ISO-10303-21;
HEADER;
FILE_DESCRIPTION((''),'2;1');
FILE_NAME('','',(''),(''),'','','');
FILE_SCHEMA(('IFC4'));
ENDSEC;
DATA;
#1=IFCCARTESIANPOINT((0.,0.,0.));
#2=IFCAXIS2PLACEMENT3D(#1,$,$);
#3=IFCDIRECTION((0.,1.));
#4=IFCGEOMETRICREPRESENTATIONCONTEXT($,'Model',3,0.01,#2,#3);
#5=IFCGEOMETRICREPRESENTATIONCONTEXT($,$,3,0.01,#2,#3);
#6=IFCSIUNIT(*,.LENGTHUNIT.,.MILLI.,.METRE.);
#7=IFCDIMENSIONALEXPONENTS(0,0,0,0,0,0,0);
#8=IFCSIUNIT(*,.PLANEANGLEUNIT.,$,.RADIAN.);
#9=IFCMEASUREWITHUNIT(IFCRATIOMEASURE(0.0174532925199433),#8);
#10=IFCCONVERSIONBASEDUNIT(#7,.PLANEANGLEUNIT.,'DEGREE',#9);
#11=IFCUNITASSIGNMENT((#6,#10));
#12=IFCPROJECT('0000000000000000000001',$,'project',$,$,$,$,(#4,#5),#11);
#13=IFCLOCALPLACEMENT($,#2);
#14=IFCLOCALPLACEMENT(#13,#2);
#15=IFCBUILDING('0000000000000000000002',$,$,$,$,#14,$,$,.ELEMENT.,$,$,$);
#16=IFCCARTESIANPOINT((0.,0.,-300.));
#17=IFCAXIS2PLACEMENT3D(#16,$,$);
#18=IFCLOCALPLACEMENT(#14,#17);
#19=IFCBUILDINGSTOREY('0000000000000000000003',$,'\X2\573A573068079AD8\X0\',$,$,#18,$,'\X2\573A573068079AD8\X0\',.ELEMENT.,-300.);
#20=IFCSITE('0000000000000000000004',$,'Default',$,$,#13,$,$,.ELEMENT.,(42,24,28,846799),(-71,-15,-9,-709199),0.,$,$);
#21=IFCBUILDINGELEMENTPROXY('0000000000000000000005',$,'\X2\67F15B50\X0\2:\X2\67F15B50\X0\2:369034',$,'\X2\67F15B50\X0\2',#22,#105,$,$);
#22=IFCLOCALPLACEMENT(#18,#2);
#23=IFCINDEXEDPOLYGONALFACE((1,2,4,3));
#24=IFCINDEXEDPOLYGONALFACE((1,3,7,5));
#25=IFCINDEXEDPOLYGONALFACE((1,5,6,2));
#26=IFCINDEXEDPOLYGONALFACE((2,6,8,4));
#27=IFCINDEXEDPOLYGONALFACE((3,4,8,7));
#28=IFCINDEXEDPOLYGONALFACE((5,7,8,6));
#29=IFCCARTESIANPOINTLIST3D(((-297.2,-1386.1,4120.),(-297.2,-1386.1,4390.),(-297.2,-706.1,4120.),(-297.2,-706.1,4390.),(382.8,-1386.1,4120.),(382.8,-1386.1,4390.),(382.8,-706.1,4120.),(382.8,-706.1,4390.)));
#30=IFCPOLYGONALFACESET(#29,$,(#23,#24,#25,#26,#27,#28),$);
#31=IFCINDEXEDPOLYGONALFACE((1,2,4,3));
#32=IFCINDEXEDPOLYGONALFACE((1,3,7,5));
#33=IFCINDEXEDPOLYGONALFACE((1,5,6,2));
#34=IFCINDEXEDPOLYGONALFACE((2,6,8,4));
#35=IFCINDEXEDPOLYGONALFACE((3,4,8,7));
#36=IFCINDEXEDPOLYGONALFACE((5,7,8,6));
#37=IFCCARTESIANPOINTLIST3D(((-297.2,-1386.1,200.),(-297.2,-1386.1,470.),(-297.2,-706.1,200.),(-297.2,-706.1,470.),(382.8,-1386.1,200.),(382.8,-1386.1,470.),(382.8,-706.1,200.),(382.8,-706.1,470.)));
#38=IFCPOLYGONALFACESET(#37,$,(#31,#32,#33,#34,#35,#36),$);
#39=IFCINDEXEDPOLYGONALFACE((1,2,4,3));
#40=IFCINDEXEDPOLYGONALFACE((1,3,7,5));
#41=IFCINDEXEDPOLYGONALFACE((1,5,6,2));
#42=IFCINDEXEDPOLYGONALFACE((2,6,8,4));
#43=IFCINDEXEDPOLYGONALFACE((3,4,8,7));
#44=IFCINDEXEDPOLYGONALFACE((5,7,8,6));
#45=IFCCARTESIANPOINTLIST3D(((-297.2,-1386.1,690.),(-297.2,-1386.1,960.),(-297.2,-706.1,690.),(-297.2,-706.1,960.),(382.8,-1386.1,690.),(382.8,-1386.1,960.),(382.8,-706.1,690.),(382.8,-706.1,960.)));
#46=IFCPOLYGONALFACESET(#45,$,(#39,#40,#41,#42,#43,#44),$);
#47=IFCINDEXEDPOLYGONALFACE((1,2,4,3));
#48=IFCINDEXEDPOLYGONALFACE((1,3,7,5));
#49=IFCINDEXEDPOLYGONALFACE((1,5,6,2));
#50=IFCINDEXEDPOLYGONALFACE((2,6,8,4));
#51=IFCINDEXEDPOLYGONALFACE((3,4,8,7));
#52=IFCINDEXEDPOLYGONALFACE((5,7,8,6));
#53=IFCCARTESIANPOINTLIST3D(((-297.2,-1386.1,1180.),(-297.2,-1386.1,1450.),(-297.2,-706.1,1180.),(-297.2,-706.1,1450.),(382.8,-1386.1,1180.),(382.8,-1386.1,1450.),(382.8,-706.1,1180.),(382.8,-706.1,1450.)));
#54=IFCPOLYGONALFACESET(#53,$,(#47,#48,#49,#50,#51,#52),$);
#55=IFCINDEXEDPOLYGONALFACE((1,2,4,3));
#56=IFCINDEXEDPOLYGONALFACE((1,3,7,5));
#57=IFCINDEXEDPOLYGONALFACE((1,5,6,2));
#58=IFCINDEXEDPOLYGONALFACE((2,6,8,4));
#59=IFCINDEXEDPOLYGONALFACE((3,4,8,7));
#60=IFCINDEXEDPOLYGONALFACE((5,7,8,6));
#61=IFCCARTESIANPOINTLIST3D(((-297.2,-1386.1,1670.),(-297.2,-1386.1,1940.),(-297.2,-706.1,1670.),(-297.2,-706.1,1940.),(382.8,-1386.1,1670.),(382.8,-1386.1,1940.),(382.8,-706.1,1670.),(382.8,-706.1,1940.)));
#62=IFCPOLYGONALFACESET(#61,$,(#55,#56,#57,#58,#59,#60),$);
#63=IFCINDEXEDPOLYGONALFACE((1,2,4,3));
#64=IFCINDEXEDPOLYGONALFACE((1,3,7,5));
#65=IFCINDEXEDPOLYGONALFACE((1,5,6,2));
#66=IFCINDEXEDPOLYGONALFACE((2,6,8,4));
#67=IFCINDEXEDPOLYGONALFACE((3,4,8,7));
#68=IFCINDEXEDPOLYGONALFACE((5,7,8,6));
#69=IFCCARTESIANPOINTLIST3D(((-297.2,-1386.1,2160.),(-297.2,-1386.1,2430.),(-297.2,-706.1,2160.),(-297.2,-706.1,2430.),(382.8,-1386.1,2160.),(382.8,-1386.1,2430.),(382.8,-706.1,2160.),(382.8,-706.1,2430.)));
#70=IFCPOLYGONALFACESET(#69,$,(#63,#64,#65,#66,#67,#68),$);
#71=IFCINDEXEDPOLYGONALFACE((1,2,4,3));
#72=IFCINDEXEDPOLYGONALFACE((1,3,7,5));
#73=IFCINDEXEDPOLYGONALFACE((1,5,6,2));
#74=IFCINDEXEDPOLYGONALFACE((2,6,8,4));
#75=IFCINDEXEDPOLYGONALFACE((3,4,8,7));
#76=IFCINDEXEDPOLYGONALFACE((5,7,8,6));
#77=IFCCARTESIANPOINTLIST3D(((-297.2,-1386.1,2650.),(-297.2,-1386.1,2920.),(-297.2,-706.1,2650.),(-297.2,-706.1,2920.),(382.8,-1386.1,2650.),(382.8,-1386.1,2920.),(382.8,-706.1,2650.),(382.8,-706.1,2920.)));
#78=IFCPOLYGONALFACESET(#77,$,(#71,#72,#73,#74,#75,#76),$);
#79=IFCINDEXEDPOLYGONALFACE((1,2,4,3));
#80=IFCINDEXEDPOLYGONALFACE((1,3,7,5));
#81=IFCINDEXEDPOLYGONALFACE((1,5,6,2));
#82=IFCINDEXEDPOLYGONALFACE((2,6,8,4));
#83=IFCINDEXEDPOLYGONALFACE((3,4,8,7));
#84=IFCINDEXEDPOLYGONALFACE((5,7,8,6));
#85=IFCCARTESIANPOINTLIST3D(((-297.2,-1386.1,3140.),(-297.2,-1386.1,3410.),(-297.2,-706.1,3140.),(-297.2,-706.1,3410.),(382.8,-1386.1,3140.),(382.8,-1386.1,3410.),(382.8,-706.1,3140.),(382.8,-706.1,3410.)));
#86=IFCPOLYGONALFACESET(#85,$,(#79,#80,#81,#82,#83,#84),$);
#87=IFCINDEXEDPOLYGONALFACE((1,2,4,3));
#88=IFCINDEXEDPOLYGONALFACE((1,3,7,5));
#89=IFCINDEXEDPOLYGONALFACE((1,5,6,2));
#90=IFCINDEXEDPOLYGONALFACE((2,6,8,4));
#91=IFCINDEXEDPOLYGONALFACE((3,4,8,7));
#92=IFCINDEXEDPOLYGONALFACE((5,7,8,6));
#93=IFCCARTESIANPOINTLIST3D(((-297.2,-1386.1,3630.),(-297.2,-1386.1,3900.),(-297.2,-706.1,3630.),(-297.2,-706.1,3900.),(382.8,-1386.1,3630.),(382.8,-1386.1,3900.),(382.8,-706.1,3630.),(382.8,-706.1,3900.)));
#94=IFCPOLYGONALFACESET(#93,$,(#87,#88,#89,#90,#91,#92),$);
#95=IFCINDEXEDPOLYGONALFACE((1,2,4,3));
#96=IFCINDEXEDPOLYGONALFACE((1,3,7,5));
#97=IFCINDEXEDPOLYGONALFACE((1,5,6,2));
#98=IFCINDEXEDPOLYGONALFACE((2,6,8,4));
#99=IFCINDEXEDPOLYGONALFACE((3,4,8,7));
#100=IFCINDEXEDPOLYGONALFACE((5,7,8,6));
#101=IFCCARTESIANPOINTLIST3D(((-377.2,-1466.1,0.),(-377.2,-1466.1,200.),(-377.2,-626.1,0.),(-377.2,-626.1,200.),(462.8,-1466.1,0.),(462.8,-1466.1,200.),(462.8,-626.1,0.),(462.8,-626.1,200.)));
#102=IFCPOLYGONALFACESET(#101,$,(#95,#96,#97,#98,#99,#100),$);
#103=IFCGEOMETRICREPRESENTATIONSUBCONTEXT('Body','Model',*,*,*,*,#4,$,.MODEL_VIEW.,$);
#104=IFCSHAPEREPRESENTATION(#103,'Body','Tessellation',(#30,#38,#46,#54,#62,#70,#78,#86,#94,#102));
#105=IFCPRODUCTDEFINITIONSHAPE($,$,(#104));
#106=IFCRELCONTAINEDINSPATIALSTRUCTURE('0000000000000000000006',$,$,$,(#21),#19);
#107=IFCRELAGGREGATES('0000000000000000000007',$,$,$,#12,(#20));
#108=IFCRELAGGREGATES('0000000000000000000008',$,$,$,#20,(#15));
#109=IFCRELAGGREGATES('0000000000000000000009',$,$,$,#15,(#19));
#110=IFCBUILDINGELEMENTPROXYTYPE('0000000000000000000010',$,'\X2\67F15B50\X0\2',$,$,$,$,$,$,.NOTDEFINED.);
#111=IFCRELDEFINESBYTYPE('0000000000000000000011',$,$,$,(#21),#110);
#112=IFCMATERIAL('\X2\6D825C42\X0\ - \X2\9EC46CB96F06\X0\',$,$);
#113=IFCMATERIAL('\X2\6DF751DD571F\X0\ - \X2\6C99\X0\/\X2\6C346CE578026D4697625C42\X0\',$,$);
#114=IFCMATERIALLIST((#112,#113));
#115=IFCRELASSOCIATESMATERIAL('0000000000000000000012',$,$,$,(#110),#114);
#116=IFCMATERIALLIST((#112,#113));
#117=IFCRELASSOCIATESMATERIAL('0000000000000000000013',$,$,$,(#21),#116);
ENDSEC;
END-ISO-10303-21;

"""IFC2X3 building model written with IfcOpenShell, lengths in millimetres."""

from ifc_helpers import new_model, entity, si_unit, converted_unit, direction, frame, origin, origin_2d_with_axis, place, context, subcontext, project, spatial, rectangle, extrude, source, transform, mapped, material, material_list, type_object, type_shapes, element, save


model = new_model("IFC2X3")

# Units and contexts
model_context = context("Model", 3, precision=0.01, world=origin(), true_north=direction((0.0, 1.0)))
context_of_model = context(None, 3, precision=0.01, world=origin(), true_north=direction((0.0, 1.0)))
body_context = subcontext(model_context, "Body", "Model", "MODEL_VIEW")
ifc_project = project(units=[si_unit("LENGTHUNIT", "METRE", prefix="MILLI"), converted_unit("PLANEANGLEUNIT", "DEGREE", entity("IfcRatioMeasure", 0.0174532925199433), si_unit("PLANEANGLEUNIT", "RADIAN"), dimensions=[0, 0, 0, 0, 0, 0, 0])], contexts=[model_context, context_of_model])

# Site, building, storey
site_placement = place(None, origin())
site = spatial("IfcSite", under=ifc_project, at=site_placement, Name="Default", CompositionType="ELEMENT", RefLatitude=(42, 24, 28, 846799), RefLongitude=(-71, -15, -9, -709199), RefElevation=0.0)
building_placement = place(site_placement, origin())
building = spatial("IfcBuilding", under=site, at=building_placement, CompositionType="ELEMENT")
storey_placement = place(building_placement, frame((0.0, 0.0, -300.0)))
storey = spatial("IfcBuildingStorey", under=building, at=storey_placement, Name="场地标高", LongName="场地标高", CompositionType="ELEMENT", Elevation=-300.0)

# Shared definitions
ifc_material_1 = material(Name="混凝土 - 沙/水泥砂浆面层")

# Building element proxy
ifc_material_2 = material(Name="涂层 - 黄油漆")
ifc_material_list_1 = material_list([ifc_material_2, ifc_material_1])
ifc_material_list_2 = material_list([ifc_material_2, ifc_material_1])
building_element_proxy_type_1 = type_object("IfcBuildingElementProxyType", Name="柱子2", PredefinedType="NOTDEFINED", material=ifc_material_list_2)
shared_shape_1 = source(origin(), body_context, "Body", "SweptSolid", [
    extrude(rectangle(XDim=680.0, YDim=680.0, at=origin_2d_with_axis()), frame((0.0, 0.0, 4120.0), z_axis=(0.0, 0.0, 1.0), x_axis=(-1.0, 0.0, 0.0)), (0.0, 0.0, 1.0), 270.0),
    extrude(rectangle(XDim=680.0, YDim=680.0, at=origin_2d_with_axis()), frame((0.0, 0.0, 200.0), z_axis=(0.0, 0.0, 1.0), x_axis=(-1.0, 0.0, 0.0)), (0.0, 0.0, 1.0), 270.0),
    extrude(rectangle(XDim=680.0, YDim=680.0, at=origin_2d_with_axis()), frame((0.0, 0.0, 690.0), z_axis=(0.0, 0.0, 1.0), x_axis=(-1.0, 0.0, 0.0)), (0.0, 0.0, 1.0), 270.0),
    extrude(rectangle(XDim=680.0, YDim=680.0, at=origin_2d_with_axis()), frame((0.0, 0.0, 1180.0), z_axis=(0.0, 0.0, 1.0), x_axis=(-1.0, 0.0, 0.0)), (0.0, 0.0, 1.0), 270.0),
    extrude(rectangle(XDim=680.0, YDim=680.0, at=origin_2d_with_axis()), frame((0.0, 0.0, 1670.0), z_axis=(0.0, 0.0, 1.0), x_axis=(-1.0, 0.0, 0.0)), (0.0, 0.0, 1.0), 270.0),
    extrude(rectangle(XDim=680.0, YDim=680.0, at=origin_2d_with_axis()), frame((0.0, 0.0, 2160.0), z_axis=(0.0, 0.0, 1.0), x_axis=(-1.0, 0.0, 0.0)), (0.0, 0.0, 1.0), 270.0),
    extrude(rectangle(XDim=680.0, YDim=680.0, at=origin_2d_with_axis()), frame((0.0, 0.0, 2650.0), z_axis=(0.0, 0.0, 1.0), x_axis=(-1.0, 0.0, 0.0)), (0.0, 0.0, 1.0), 270.0),
    extrude(rectangle(XDim=680.0, YDim=680.0, at=origin_2d_with_axis()), frame((0.0, 0.0, 3140.0), z_axis=(0.0, 0.0, 1.0), x_axis=(-1.0, 0.0, 0.0)), (0.0, 0.0, 1.0), 270.0),
    extrude(rectangle(XDim=680.0, YDim=680.0, at=origin_2d_with_axis()), frame((0.0, 0.0, 3630.0), z_axis=(0.0, 0.0, 1.0), x_axis=(-1.0, 0.0, 0.0)), (0.0, 0.0, 1.0), 270.0),
    extrude(rectangle(XDim=840.0, YDim=840.0, at=origin_2d_with_axis()), frame((0.0, 0.0, 0.0), z_axis=(0.0, 0.0, 1.0), x_axis=(-1.0, 0.0, 0.0)), (0.0, 0.0, 1.0), 200.0),
])
type_shapes(building_element_proxy_type_1, [shared_shape_1])
proxy_1_placement = place(storey_placement, frame((42.8, -1046.1, 0.0), z_axis=(0.0, 0.0, 1.0), x_axis=(-1.0, 0.0, 0.0)))
element("IfcBuildingElementProxy", 1, at=proxy_1_placement, inside=storey, type_object=building_element_proxy_type_1, material=ifc_material_list_1, Name="柱子2:柱子2:369034", ObjectType="柱子2", context=body_context, shape_type="MappedRepresentation", body=[
    mapped(shared_shape_1, transform((0.0, 0.0, 0.0), scale=1.0)),
])

save(model, "model.ifc")
